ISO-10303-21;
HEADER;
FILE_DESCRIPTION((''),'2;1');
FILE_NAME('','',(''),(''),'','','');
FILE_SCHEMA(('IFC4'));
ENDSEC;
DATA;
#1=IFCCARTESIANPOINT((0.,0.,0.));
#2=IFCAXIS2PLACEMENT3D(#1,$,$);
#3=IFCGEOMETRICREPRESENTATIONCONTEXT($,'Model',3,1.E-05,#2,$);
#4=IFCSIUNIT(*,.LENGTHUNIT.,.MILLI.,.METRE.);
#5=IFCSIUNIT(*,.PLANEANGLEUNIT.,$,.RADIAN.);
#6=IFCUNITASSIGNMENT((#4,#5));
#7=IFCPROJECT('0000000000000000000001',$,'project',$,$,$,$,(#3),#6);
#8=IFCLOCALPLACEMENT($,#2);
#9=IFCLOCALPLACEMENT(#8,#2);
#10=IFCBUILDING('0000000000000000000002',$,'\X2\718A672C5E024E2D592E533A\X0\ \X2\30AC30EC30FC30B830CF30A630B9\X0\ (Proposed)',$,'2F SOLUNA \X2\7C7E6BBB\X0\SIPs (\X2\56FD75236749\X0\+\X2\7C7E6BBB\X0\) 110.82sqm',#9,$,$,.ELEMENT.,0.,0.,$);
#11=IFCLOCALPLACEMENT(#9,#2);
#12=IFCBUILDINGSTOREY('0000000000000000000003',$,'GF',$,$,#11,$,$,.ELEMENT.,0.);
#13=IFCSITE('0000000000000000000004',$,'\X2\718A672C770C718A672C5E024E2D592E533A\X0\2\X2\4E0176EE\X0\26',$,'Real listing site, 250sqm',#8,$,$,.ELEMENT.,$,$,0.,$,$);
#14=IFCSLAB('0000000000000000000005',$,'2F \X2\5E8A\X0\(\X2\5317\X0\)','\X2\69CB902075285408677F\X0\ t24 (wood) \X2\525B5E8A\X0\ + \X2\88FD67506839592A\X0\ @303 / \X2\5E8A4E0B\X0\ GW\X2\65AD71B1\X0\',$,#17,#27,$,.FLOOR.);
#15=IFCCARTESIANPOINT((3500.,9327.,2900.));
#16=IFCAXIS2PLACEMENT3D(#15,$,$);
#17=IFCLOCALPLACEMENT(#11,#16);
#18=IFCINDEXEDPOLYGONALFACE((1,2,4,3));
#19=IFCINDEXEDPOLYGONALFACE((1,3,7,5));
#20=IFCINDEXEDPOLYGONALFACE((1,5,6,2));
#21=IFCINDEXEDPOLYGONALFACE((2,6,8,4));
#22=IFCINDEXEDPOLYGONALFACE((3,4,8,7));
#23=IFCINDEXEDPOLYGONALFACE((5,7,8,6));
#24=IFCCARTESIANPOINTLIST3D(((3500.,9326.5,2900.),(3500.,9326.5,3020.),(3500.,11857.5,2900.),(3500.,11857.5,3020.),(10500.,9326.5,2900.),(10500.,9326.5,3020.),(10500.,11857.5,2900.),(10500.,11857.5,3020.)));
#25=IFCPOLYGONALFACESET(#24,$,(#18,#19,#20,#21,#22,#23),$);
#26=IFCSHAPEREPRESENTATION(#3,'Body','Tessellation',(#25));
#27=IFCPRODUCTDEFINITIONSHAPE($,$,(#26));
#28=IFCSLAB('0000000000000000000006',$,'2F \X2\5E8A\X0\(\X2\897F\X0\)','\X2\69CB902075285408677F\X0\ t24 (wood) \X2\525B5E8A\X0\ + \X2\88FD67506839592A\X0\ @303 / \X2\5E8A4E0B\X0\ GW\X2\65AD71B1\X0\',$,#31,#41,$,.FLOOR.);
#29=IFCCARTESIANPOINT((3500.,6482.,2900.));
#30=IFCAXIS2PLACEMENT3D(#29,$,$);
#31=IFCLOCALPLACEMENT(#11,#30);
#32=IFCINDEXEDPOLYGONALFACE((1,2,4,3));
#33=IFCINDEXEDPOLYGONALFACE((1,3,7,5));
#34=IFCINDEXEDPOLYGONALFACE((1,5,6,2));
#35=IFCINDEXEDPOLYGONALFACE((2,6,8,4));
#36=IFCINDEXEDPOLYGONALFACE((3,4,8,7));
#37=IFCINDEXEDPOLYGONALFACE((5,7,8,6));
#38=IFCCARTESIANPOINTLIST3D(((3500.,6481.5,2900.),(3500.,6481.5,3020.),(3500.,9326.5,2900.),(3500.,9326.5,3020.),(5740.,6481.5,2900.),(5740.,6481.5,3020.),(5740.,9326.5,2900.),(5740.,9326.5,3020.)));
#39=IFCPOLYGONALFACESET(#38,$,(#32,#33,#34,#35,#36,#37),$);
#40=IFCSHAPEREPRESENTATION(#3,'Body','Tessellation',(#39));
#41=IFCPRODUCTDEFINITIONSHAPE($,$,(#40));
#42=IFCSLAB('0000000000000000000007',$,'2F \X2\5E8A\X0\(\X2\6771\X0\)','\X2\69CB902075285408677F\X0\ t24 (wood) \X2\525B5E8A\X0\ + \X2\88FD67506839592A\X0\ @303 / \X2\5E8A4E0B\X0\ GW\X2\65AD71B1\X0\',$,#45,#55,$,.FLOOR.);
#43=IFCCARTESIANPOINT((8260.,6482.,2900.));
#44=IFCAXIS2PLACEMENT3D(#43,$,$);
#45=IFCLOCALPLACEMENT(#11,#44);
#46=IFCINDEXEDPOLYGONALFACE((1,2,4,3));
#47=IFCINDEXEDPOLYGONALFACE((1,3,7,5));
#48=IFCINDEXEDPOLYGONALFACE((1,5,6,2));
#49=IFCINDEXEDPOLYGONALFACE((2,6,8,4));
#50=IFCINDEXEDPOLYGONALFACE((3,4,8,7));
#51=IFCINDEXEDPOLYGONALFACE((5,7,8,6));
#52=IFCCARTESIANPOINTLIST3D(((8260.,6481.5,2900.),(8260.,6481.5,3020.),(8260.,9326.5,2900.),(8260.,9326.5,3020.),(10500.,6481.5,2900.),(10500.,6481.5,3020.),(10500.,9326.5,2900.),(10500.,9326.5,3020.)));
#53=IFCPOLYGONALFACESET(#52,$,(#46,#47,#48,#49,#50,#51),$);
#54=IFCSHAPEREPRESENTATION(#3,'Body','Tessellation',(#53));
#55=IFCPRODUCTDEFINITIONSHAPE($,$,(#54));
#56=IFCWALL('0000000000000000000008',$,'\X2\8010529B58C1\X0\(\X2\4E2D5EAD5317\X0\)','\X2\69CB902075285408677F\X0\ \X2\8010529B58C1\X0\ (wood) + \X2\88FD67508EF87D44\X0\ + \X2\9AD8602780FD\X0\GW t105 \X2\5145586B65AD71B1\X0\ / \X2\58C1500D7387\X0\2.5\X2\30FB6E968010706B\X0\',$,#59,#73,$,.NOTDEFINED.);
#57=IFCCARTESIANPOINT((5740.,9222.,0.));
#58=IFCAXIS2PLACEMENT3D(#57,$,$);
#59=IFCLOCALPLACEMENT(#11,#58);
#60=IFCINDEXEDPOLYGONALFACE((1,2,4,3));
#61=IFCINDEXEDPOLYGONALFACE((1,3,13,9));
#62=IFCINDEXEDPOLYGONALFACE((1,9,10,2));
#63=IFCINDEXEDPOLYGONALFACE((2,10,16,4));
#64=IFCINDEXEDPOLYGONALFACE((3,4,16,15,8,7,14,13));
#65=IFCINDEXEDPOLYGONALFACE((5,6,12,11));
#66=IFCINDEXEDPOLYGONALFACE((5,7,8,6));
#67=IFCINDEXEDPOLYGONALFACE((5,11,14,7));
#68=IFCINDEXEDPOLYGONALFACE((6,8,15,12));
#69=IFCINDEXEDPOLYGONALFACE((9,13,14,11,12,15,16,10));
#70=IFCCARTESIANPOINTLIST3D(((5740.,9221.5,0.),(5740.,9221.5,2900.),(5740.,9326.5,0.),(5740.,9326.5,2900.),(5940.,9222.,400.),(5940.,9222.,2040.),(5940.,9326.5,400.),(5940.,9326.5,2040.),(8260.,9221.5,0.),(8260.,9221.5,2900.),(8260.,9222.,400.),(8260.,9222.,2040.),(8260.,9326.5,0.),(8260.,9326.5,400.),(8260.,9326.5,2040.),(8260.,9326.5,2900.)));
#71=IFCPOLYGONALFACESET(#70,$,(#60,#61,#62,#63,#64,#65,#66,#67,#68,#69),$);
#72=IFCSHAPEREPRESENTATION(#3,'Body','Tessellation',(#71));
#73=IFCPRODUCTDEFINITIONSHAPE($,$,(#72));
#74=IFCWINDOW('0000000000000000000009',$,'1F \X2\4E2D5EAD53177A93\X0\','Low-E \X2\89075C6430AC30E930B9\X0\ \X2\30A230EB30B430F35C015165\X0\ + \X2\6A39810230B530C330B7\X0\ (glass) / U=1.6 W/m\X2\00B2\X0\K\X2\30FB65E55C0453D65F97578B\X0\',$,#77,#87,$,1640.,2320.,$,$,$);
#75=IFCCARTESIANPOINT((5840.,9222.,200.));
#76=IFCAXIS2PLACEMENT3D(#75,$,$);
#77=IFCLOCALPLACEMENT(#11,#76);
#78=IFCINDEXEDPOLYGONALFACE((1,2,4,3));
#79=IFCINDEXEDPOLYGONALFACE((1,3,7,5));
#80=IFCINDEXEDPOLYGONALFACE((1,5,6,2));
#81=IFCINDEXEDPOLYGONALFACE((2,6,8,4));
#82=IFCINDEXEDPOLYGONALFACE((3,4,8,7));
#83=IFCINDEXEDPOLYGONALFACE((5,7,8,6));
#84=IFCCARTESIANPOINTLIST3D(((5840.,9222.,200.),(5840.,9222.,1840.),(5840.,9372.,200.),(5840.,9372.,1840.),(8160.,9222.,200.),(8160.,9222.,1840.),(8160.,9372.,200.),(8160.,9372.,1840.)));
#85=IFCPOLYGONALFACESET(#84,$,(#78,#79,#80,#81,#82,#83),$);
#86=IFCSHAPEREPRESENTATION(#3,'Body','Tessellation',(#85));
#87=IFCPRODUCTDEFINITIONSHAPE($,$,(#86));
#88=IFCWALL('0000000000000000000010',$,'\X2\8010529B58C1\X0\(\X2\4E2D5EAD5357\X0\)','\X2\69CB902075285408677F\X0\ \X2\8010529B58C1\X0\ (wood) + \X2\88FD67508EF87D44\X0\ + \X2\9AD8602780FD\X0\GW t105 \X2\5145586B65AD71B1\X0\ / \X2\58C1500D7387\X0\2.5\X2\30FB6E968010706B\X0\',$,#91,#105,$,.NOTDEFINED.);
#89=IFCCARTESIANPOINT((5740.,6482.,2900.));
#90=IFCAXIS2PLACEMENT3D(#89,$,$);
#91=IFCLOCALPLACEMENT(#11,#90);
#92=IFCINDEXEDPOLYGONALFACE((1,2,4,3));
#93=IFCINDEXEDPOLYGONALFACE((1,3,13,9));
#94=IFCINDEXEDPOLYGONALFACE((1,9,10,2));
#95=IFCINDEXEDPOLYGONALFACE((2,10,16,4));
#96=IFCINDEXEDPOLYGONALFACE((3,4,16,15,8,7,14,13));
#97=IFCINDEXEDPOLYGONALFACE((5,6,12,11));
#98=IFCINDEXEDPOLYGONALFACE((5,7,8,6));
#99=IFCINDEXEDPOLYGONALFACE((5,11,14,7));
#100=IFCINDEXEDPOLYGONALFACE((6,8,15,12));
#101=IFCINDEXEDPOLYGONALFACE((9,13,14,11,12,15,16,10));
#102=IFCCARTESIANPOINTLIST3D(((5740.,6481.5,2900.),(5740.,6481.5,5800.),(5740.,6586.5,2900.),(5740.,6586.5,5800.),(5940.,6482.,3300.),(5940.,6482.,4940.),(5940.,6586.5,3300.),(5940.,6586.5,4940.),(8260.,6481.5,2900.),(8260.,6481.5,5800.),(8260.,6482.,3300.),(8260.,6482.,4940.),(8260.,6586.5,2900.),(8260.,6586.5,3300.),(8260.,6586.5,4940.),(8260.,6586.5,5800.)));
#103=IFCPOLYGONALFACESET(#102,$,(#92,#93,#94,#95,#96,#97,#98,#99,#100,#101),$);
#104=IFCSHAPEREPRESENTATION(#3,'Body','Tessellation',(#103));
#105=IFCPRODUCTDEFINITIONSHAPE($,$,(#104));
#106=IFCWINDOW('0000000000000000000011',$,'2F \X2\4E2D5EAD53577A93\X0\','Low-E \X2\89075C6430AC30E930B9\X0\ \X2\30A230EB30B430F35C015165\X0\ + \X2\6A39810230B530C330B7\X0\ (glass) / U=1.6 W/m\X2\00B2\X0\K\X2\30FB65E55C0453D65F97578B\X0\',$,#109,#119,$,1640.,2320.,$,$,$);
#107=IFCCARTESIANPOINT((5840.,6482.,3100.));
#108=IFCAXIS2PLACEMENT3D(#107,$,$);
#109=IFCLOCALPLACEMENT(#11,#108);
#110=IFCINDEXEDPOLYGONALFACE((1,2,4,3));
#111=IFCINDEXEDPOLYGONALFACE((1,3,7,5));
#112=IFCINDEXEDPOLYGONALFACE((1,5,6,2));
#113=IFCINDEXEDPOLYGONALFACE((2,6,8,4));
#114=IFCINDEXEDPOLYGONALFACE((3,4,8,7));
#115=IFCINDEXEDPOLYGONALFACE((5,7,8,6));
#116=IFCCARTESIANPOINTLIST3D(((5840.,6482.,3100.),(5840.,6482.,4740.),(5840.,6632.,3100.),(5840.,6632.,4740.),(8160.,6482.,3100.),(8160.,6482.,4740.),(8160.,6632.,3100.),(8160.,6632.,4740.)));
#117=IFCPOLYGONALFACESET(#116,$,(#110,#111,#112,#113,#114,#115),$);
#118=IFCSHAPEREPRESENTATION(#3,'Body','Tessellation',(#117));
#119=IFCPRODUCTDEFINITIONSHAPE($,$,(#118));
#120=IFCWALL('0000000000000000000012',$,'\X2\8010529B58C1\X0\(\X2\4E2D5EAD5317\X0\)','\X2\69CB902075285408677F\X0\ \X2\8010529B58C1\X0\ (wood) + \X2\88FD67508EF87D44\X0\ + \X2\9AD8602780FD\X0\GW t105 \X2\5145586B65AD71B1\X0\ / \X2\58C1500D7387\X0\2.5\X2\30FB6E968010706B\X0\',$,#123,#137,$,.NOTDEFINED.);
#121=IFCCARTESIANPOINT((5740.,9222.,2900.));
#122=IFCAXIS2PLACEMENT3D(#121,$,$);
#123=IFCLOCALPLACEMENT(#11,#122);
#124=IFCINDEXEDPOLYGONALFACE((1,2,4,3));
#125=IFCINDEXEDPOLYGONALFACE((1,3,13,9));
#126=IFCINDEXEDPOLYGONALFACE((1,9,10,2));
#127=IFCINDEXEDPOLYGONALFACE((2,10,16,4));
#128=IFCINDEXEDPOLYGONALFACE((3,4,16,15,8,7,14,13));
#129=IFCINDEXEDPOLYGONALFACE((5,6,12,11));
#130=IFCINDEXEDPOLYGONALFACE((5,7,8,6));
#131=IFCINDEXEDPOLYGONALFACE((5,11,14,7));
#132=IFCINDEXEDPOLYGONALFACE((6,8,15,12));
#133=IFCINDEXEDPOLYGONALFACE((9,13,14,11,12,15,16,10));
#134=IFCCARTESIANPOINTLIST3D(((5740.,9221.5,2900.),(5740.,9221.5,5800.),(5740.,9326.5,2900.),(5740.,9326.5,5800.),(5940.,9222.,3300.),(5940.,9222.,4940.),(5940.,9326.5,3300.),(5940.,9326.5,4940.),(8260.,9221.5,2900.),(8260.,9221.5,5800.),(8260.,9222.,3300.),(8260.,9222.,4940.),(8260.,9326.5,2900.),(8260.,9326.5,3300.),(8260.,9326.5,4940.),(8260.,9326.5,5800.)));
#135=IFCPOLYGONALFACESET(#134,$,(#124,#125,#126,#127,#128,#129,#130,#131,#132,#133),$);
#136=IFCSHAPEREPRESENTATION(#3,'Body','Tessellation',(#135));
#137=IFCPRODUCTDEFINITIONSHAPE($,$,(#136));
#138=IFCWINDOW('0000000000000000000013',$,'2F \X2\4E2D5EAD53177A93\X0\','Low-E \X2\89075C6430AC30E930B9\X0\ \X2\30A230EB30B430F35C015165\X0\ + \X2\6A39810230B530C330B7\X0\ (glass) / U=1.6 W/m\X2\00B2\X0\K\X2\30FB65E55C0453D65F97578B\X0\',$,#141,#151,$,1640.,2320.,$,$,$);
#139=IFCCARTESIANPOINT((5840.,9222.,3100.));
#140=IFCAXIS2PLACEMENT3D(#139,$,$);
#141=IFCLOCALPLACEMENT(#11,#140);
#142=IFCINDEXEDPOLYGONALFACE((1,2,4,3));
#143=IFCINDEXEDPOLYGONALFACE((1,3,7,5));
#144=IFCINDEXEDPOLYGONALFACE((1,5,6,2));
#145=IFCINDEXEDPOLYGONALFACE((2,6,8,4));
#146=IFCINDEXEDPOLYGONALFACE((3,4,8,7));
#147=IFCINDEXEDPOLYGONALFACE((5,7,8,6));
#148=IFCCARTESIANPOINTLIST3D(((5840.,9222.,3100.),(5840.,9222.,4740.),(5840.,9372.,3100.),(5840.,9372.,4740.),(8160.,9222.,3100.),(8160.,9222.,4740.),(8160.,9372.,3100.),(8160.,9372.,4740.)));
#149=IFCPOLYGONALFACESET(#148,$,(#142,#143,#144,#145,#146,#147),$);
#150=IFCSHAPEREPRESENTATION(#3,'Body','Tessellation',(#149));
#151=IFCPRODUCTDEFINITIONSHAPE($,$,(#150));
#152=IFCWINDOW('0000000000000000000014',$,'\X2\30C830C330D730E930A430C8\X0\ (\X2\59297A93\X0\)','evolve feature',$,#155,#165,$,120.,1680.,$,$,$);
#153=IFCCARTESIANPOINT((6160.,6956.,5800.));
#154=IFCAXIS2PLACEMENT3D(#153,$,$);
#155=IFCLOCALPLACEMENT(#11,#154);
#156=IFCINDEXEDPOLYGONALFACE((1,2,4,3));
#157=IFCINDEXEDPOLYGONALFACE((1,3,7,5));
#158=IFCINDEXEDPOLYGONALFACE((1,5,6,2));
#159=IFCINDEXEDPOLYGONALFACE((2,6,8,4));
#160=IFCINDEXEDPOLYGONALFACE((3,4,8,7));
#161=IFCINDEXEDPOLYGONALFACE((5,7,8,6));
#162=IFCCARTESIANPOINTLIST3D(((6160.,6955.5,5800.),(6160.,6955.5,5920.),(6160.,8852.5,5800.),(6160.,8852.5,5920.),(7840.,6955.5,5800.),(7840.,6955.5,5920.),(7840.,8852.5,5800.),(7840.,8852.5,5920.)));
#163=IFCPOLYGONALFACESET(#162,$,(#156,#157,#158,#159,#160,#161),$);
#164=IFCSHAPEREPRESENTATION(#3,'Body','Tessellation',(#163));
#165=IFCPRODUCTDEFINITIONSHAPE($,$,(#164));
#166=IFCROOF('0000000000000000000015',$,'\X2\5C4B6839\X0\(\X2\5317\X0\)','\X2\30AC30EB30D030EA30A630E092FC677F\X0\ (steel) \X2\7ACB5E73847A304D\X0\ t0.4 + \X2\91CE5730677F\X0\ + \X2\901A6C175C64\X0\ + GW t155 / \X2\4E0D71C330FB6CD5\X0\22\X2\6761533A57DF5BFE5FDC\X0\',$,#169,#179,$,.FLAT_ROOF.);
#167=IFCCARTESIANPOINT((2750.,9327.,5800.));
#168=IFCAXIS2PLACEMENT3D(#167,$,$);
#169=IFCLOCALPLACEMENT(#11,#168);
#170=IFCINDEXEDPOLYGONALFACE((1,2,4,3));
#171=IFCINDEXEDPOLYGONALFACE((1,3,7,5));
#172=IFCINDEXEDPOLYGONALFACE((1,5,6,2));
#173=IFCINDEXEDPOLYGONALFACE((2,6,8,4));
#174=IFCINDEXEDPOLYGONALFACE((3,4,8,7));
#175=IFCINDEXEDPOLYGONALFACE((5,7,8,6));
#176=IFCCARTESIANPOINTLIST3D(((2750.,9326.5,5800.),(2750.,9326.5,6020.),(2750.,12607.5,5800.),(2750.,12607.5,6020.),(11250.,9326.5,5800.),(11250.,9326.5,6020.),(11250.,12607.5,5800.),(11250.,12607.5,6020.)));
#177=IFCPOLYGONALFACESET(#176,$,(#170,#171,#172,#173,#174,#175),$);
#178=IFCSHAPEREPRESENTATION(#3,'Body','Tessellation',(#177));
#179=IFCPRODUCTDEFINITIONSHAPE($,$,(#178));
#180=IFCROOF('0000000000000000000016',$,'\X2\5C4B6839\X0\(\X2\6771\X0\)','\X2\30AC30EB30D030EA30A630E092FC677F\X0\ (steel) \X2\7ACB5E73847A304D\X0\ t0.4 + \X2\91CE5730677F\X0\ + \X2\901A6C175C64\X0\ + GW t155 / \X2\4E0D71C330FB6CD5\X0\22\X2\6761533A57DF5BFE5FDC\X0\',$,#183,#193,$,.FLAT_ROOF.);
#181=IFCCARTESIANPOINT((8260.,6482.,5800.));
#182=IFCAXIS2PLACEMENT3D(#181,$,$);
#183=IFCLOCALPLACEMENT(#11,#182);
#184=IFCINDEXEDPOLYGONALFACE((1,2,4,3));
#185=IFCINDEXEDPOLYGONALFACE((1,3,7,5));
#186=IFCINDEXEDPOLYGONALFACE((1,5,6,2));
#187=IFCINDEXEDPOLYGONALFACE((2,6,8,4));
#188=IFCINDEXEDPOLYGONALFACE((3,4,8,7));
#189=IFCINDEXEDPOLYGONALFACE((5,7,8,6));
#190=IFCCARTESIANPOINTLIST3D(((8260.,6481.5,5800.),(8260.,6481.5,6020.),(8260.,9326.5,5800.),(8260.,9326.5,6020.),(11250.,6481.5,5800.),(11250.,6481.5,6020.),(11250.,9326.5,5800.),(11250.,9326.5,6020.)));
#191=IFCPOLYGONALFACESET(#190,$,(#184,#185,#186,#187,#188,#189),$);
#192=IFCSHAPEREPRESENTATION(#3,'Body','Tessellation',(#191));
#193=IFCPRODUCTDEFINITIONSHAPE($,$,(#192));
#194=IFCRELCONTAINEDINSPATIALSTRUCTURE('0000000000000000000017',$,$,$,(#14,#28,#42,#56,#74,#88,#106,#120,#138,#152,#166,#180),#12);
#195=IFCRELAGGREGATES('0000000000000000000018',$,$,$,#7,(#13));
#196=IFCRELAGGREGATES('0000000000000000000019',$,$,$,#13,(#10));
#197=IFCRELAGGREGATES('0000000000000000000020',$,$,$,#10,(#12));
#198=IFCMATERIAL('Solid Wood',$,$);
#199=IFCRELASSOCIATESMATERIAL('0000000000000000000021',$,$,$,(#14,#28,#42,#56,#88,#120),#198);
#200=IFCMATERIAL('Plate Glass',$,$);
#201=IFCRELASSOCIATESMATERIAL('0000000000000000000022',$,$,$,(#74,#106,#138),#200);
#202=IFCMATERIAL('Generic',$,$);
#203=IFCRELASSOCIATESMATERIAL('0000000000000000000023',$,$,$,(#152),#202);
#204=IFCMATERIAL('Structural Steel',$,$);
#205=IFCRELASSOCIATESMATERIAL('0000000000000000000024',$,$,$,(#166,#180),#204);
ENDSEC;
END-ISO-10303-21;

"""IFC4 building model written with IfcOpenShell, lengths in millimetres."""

from ifc_helpers import new_model, si_unit, frame, frame_2d, origin, place, context, project, spatial, rectangle, extrude, material, element, fill, save


model = new_model("IFC4")

# Units and contexts
model_context = context("Model", 3, precision=1e-05, world=origin())
ifc_project = project(units=[si_unit("LENGTHUNIT", "METRE", prefix="MILLI"), si_unit("PLANEANGLEUNIT", "RADIAN")], contexts=[model_context])

# Site, building, storey
site_placement = place(None, origin())
site = spatial("IfcSite", under=ifc_project, at=site_placement, Name="熊本県熊本市中央区2丁目26", ObjectType="Real listing site, 250sqm", CompositionType="ELEMENT", RefElevation=0.0)
building_placement = place(site_placement, origin())
building = spatial("IfcBuilding", under=site, at=building_placement, Name="熊本市中央区 ガレージハウス (Proposed)", ObjectType="2F SOLUNA 籾殻SIPs (国産杉+籾殻) 110.82sqm", CompositionType="ELEMENT", ElevationOfRefHeight=0.0, ElevationOfTerrain=0.0)
storey_placement = place(building_placement, origin())
storey = spatial("IfcBuildingStorey", under=building, at=storey_placement, Name="GF", CompositionType="ELEMENT", Elevation=0.0)

# Slabs
ifc_material_1 = material(Name="Solid Wood")
slab_1_placement = place(storey_placement, frame((3500.0, 9327.0, 2900.0)))
element("IfcSlab", 1, at=slab_1_placement, inside=storey, material=ifc_material_1, Name="2F 床(北)", Description="構造用合板 t24 (wood) 剛床 + 製材根太 @303 / 床下 GW断熱", PredefinedType="FLOOR", context=model_context, shape_type="SweptSolid", body=[
    extrude(rectangle(XDim=7000.0, YDim=2531.0, at=frame_2d((3500.0, 1265.0))), frame((3500.0, 9327.0, 2900.0)), (0.0, 0.0, 1.0), 120.0),
])
slab_2_placement = place(storey_placement, frame((3500.0, 6482.0, 2900.0)))
element("IfcSlab", 2, at=slab_2_placement, inside=storey, material=ifc_material_1, Name="2F 床(西)", Description="構造用合板 t24 (wood) 剛床 + 製材根太 @303 / 床下 GW断熱", PredefinedType="FLOOR", context=model_context, shape_type="SweptSolid", body=[
    extrude(rectangle(XDim=2240.0, YDim=2845.0, at=frame_2d((1120.0, 1422.0))), frame((3500.0, 6482.0, 2900.0)), (0.0, 0.0, 1.0), 120.0),
])
slab_3_placement = place(storey_placement, frame((8260.0, 6482.0, 2900.0)))
element("IfcSlab", 3, at=slab_3_placement, inside=storey, material=ifc_material_1, Name="2F 床(東)", Description="構造用合板 t24 (wood) 剛床 + 製材根太 @303 / 床下 GW断熱", PredefinedType="FLOOR", context=model_context, shape_type="SweptSolid", body=[
    extrude(rectangle(XDim=2240.0, YDim=2845.0, at=frame_2d((1120.0, 1422.0))), frame((8260.0, 6482.0, 2900.0)), (0.0, 0.0, 1.0), 120.0),
])

# Wall, opening, window
wall_1_placement = place(storey_placement, frame((5740.0, 9222.0, 0.0)))
wall_1 = element("IfcWall", 4, at=wall_1_placement, inside=storey, material=ifc_material_1, Name="耐力壁(中庭北)", Description="構造用合板 耐力壁 (wood) + 製材軸組 + 高性能GW t105 充填断熱 / 壁倍率2.5・準耐火", PredefinedType="NOTDEFINED", context=model_context, shape_type="SweptSolid", body=[
    extrude(rectangle(XDim=2520.0, YDim=105.0, at=frame_2d((1260.0, 52.0))), frame((5740.0, 9222.0, 0.0)), (0.0, 0.0, 1.0), 2900.0),
])
opening_1_placement = place(storey_placement, frame((5840.0, 9222.0, 200.0)))
opening_1 = element("IfcOpeningElement", 5, at=opening_1_placement, cuts=wall_1, PredefinedType="NOTDEFINED", context=model_context, shape_type="SweptSolid", body=[
    extrude(rectangle(XDim=2320.0, YDim=150.0, at=frame_2d((1160.0, 75.0))), frame((5840.0, 9222.0, 200.0)), (0.0, 0.0, 1.0), 1640.0),
])
ifc_material_2 = material(Name="Plate Glass")
window_1_placement = place(storey_placement, frame((5840.0, 9222.0, 200.0)))
window_1 = element("IfcWindow", 6, at=window_1_placement, inside=storey, material=ifc_material_2, Name="1F 中庭北窓", Description="Low-E 複層ガラス アルゴン封入 + 樹脂サッシ (glass) / U=1.6 W/m²K・日射取得型", OverallHeight=1640.0, OverallWidth=2320.0, context=model_context, shape_type="SweptSolid", body=[
    extrude(rectangle(XDim=2320.0, YDim=150.0, at=frame_2d((1160.0, 75.0))), frame((5840.0, 9222.0, 200.0)), (0.0, 0.0, 1.0), 1640.0),
])
fill(opening_1, window_1)

# Walls, openings, windows
wall_2_placement = place(storey_placement, frame((5740.0, 6482.0, 2900.0)))
wall_2 = element("IfcWall", 7, at=wall_2_placement, inside=storey, material=ifc_material_1, Name="耐力壁(中庭南)", Description="構造用合板 耐力壁 (wood) + 製材軸組 + 高性能GW t105 充填断熱 / 壁倍率2.5・準耐火", PredefinedType="NOTDEFINED", context=model_context, shape_type="SweptSolid", body=[
    extrude(rectangle(XDim=2520.0, YDim=105.0, at=frame_2d((1260.0, 52.0))), frame((5740.0, 6482.0, 2900.0)), (0.0, 0.0, 1.0), 2900.0),
])
opening_2_placement = place(storey_placement, frame((5840.0, 6482.0, 3100.0)))
opening_2 = element("IfcOpeningElement", 8, at=opening_2_placement, cuts=wall_2, PredefinedType="NOTDEFINED", context=model_context, shape_type="SweptSolid", body=[
    extrude(rectangle(XDim=2320.0, YDim=150.0, at=frame_2d((1160.0, 75.0))), frame((5840.0, 6482.0, 3100.0)), (0.0, 0.0, 1.0), 1640.0),
])
window_2_placement = place(storey_placement, frame((5840.0, 6482.0, 3100.0)))
window_2 = element("IfcWindow", 9, at=window_2_placement, inside=storey, material=ifc_material_2, Name="2F 中庭南窓", Description="Low-E 複層ガラス アルゴン封入 + 樹脂サッシ (glass) / U=1.6 W/m²K・日射取得型", OverallHeight=1640.0, OverallWidth=2320.0, context=model_context, shape_type="SweptSolid", body=[
    extrude(rectangle(XDim=2320.0, YDim=150.0, at=frame_2d((1160.0, 75.0))), frame((5840.0, 6482.0, 3100.0)), (0.0, 0.0, 1.0), 1640.0),
])
fill(opening_2, window_2)
wall_3_placement = place(storey_placement, frame((5740.0, 9222.0, 2900.0)))
wall_3 = element("IfcWall", 10, at=wall_3_placement, inside=storey, material=ifc_material_1, Name="耐力壁(中庭北)", Description="構造用合板 耐力壁 (wood) + 製材軸組 + 高性能GW t105 充填断熱 / 壁倍率2.5・準耐火", PredefinedType="NOTDEFINED", context=model_context, shape_type="SweptSolid", body=[
    extrude(rectangle(XDim=2520.0, YDim=105.0, at=frame_2d((1260.0, 52.0))), frame((5740.0, 9222.0, 2900.0)), (0.0, 0.0, 1.0), 2900.0),
])
opening_3_placement = place(storey_placement, frame((5840.0, 9222.0, 3100.0)))
opening_3 = element("IfcOpeningElement", 11, at=opening_3_placement, cuts=wall_3, PredefinedType="NOTDEFINED", context=model_context, shape_type="SweptSolid", body=[
    extrude(rectangle(XDim=2320.0, YDim=150.0, at=frame_2d((1160.0, 75.0))), frame((5840.0, 9222.0, 3100.0)), (0.0, 0.0, 1.0), 1640.0),
])
window_3_placement = place(storey_placement, frame((5840.0, 9222.0, 3100.0)))
window_3 = element("IfcWindow", 12, at=window_3_placement, inside=storey, material=ifc_material_2, Name="2F 中庭北窓", Description="Low-E 複層ガラス アルゴン封入 + 樹脂サッシ (glass) / U=1.6 W/m²K・日射取得型", OverallHeight=1640.0, OverallWidth=2320.0, context=model_context, shape_type="SweptSolid", body=[
    extrude(rectangle(XDim=2320.0, YDim=150.0, at=frame_2d((1160.0, 75.0))), frame((5840.0, 9222.0, 3100.0)), (0.0, 0.0, 1.0), 1640.0),
])
fill(opening_3, window_3)

# Window
ifc_material_3 = material(Name="Generic")
window_4_placement = place(storey_placement, frame((6160.0, 6956.0, 5800.0)))
element("IfcWindow", 13, at=window_4_placement, inside=storey, material=ifc_material_3, Name="トップライト (天窓)", Description="evolve feature", OverallHeight=120.0, OverallWidth=1680.0, context=model_context, shape_type="SweptSolid", body=[
    extrude(rectangle(XDim=1680.0, YDim=1897.0, at=frame_2d((840.0, 948.0))), frame((6160.0, 6956.0, 5800.0)), (0.0, 0.0, 1.0), 120.0),
])

# Roofs
ifc_material_4 = material(Name="Structural Steel")
roof_1_placement = place(storey_placement, frame((2750.0, 9327.0, 5800.0)))
element("IfcRoof", 14, at=roof_1_placement, inside=storey, material=ifc_material_4, Name="屋根(北)", Description="ガルバリウム鋼板 (steel) 立平葺き t0.4 + 野地板 + 通気層 + GW t155 / 不燃・法22条区域対応", PredefinedType="FLAT_ROOF", context=model_context, shape_type="SweptSolid", body=[
    extrude(rectangle(XDim=8500.0, YDim=3281.0, at=frame_2d((4250.0, 1640.0))), frame((2750.0, 9327.0, 5800.0)), (0.0, 0.0, 1.0), 220.0),
])
roof_2_placement = place(storey_placement, frame((8260.0, 6482.0, 5800.0)))
element("IfcRoof", 15, at=roof_2_placement, inside=storey, material=ifc_material_4, Name="屋根(東)", Description="ガルバリウム鋼板 (steel) 立平葺き t0.4 + 野地板 + 通気層 + GW t155 / 不燃・法22条区域対応", PredefinedType="FLAT_ROOF", context=model_context, shape_type="SweptSolid", body=[
    extrude(rectangle(XDim=2990.0, YDim=2845.0, at=frame_2d((1495.0, 1422.0))), frame((8260.0, 6482.0, 5800.0)), (0.0, 0.0, 1.0), 220.0),
])

save(model, "model.ifc")
